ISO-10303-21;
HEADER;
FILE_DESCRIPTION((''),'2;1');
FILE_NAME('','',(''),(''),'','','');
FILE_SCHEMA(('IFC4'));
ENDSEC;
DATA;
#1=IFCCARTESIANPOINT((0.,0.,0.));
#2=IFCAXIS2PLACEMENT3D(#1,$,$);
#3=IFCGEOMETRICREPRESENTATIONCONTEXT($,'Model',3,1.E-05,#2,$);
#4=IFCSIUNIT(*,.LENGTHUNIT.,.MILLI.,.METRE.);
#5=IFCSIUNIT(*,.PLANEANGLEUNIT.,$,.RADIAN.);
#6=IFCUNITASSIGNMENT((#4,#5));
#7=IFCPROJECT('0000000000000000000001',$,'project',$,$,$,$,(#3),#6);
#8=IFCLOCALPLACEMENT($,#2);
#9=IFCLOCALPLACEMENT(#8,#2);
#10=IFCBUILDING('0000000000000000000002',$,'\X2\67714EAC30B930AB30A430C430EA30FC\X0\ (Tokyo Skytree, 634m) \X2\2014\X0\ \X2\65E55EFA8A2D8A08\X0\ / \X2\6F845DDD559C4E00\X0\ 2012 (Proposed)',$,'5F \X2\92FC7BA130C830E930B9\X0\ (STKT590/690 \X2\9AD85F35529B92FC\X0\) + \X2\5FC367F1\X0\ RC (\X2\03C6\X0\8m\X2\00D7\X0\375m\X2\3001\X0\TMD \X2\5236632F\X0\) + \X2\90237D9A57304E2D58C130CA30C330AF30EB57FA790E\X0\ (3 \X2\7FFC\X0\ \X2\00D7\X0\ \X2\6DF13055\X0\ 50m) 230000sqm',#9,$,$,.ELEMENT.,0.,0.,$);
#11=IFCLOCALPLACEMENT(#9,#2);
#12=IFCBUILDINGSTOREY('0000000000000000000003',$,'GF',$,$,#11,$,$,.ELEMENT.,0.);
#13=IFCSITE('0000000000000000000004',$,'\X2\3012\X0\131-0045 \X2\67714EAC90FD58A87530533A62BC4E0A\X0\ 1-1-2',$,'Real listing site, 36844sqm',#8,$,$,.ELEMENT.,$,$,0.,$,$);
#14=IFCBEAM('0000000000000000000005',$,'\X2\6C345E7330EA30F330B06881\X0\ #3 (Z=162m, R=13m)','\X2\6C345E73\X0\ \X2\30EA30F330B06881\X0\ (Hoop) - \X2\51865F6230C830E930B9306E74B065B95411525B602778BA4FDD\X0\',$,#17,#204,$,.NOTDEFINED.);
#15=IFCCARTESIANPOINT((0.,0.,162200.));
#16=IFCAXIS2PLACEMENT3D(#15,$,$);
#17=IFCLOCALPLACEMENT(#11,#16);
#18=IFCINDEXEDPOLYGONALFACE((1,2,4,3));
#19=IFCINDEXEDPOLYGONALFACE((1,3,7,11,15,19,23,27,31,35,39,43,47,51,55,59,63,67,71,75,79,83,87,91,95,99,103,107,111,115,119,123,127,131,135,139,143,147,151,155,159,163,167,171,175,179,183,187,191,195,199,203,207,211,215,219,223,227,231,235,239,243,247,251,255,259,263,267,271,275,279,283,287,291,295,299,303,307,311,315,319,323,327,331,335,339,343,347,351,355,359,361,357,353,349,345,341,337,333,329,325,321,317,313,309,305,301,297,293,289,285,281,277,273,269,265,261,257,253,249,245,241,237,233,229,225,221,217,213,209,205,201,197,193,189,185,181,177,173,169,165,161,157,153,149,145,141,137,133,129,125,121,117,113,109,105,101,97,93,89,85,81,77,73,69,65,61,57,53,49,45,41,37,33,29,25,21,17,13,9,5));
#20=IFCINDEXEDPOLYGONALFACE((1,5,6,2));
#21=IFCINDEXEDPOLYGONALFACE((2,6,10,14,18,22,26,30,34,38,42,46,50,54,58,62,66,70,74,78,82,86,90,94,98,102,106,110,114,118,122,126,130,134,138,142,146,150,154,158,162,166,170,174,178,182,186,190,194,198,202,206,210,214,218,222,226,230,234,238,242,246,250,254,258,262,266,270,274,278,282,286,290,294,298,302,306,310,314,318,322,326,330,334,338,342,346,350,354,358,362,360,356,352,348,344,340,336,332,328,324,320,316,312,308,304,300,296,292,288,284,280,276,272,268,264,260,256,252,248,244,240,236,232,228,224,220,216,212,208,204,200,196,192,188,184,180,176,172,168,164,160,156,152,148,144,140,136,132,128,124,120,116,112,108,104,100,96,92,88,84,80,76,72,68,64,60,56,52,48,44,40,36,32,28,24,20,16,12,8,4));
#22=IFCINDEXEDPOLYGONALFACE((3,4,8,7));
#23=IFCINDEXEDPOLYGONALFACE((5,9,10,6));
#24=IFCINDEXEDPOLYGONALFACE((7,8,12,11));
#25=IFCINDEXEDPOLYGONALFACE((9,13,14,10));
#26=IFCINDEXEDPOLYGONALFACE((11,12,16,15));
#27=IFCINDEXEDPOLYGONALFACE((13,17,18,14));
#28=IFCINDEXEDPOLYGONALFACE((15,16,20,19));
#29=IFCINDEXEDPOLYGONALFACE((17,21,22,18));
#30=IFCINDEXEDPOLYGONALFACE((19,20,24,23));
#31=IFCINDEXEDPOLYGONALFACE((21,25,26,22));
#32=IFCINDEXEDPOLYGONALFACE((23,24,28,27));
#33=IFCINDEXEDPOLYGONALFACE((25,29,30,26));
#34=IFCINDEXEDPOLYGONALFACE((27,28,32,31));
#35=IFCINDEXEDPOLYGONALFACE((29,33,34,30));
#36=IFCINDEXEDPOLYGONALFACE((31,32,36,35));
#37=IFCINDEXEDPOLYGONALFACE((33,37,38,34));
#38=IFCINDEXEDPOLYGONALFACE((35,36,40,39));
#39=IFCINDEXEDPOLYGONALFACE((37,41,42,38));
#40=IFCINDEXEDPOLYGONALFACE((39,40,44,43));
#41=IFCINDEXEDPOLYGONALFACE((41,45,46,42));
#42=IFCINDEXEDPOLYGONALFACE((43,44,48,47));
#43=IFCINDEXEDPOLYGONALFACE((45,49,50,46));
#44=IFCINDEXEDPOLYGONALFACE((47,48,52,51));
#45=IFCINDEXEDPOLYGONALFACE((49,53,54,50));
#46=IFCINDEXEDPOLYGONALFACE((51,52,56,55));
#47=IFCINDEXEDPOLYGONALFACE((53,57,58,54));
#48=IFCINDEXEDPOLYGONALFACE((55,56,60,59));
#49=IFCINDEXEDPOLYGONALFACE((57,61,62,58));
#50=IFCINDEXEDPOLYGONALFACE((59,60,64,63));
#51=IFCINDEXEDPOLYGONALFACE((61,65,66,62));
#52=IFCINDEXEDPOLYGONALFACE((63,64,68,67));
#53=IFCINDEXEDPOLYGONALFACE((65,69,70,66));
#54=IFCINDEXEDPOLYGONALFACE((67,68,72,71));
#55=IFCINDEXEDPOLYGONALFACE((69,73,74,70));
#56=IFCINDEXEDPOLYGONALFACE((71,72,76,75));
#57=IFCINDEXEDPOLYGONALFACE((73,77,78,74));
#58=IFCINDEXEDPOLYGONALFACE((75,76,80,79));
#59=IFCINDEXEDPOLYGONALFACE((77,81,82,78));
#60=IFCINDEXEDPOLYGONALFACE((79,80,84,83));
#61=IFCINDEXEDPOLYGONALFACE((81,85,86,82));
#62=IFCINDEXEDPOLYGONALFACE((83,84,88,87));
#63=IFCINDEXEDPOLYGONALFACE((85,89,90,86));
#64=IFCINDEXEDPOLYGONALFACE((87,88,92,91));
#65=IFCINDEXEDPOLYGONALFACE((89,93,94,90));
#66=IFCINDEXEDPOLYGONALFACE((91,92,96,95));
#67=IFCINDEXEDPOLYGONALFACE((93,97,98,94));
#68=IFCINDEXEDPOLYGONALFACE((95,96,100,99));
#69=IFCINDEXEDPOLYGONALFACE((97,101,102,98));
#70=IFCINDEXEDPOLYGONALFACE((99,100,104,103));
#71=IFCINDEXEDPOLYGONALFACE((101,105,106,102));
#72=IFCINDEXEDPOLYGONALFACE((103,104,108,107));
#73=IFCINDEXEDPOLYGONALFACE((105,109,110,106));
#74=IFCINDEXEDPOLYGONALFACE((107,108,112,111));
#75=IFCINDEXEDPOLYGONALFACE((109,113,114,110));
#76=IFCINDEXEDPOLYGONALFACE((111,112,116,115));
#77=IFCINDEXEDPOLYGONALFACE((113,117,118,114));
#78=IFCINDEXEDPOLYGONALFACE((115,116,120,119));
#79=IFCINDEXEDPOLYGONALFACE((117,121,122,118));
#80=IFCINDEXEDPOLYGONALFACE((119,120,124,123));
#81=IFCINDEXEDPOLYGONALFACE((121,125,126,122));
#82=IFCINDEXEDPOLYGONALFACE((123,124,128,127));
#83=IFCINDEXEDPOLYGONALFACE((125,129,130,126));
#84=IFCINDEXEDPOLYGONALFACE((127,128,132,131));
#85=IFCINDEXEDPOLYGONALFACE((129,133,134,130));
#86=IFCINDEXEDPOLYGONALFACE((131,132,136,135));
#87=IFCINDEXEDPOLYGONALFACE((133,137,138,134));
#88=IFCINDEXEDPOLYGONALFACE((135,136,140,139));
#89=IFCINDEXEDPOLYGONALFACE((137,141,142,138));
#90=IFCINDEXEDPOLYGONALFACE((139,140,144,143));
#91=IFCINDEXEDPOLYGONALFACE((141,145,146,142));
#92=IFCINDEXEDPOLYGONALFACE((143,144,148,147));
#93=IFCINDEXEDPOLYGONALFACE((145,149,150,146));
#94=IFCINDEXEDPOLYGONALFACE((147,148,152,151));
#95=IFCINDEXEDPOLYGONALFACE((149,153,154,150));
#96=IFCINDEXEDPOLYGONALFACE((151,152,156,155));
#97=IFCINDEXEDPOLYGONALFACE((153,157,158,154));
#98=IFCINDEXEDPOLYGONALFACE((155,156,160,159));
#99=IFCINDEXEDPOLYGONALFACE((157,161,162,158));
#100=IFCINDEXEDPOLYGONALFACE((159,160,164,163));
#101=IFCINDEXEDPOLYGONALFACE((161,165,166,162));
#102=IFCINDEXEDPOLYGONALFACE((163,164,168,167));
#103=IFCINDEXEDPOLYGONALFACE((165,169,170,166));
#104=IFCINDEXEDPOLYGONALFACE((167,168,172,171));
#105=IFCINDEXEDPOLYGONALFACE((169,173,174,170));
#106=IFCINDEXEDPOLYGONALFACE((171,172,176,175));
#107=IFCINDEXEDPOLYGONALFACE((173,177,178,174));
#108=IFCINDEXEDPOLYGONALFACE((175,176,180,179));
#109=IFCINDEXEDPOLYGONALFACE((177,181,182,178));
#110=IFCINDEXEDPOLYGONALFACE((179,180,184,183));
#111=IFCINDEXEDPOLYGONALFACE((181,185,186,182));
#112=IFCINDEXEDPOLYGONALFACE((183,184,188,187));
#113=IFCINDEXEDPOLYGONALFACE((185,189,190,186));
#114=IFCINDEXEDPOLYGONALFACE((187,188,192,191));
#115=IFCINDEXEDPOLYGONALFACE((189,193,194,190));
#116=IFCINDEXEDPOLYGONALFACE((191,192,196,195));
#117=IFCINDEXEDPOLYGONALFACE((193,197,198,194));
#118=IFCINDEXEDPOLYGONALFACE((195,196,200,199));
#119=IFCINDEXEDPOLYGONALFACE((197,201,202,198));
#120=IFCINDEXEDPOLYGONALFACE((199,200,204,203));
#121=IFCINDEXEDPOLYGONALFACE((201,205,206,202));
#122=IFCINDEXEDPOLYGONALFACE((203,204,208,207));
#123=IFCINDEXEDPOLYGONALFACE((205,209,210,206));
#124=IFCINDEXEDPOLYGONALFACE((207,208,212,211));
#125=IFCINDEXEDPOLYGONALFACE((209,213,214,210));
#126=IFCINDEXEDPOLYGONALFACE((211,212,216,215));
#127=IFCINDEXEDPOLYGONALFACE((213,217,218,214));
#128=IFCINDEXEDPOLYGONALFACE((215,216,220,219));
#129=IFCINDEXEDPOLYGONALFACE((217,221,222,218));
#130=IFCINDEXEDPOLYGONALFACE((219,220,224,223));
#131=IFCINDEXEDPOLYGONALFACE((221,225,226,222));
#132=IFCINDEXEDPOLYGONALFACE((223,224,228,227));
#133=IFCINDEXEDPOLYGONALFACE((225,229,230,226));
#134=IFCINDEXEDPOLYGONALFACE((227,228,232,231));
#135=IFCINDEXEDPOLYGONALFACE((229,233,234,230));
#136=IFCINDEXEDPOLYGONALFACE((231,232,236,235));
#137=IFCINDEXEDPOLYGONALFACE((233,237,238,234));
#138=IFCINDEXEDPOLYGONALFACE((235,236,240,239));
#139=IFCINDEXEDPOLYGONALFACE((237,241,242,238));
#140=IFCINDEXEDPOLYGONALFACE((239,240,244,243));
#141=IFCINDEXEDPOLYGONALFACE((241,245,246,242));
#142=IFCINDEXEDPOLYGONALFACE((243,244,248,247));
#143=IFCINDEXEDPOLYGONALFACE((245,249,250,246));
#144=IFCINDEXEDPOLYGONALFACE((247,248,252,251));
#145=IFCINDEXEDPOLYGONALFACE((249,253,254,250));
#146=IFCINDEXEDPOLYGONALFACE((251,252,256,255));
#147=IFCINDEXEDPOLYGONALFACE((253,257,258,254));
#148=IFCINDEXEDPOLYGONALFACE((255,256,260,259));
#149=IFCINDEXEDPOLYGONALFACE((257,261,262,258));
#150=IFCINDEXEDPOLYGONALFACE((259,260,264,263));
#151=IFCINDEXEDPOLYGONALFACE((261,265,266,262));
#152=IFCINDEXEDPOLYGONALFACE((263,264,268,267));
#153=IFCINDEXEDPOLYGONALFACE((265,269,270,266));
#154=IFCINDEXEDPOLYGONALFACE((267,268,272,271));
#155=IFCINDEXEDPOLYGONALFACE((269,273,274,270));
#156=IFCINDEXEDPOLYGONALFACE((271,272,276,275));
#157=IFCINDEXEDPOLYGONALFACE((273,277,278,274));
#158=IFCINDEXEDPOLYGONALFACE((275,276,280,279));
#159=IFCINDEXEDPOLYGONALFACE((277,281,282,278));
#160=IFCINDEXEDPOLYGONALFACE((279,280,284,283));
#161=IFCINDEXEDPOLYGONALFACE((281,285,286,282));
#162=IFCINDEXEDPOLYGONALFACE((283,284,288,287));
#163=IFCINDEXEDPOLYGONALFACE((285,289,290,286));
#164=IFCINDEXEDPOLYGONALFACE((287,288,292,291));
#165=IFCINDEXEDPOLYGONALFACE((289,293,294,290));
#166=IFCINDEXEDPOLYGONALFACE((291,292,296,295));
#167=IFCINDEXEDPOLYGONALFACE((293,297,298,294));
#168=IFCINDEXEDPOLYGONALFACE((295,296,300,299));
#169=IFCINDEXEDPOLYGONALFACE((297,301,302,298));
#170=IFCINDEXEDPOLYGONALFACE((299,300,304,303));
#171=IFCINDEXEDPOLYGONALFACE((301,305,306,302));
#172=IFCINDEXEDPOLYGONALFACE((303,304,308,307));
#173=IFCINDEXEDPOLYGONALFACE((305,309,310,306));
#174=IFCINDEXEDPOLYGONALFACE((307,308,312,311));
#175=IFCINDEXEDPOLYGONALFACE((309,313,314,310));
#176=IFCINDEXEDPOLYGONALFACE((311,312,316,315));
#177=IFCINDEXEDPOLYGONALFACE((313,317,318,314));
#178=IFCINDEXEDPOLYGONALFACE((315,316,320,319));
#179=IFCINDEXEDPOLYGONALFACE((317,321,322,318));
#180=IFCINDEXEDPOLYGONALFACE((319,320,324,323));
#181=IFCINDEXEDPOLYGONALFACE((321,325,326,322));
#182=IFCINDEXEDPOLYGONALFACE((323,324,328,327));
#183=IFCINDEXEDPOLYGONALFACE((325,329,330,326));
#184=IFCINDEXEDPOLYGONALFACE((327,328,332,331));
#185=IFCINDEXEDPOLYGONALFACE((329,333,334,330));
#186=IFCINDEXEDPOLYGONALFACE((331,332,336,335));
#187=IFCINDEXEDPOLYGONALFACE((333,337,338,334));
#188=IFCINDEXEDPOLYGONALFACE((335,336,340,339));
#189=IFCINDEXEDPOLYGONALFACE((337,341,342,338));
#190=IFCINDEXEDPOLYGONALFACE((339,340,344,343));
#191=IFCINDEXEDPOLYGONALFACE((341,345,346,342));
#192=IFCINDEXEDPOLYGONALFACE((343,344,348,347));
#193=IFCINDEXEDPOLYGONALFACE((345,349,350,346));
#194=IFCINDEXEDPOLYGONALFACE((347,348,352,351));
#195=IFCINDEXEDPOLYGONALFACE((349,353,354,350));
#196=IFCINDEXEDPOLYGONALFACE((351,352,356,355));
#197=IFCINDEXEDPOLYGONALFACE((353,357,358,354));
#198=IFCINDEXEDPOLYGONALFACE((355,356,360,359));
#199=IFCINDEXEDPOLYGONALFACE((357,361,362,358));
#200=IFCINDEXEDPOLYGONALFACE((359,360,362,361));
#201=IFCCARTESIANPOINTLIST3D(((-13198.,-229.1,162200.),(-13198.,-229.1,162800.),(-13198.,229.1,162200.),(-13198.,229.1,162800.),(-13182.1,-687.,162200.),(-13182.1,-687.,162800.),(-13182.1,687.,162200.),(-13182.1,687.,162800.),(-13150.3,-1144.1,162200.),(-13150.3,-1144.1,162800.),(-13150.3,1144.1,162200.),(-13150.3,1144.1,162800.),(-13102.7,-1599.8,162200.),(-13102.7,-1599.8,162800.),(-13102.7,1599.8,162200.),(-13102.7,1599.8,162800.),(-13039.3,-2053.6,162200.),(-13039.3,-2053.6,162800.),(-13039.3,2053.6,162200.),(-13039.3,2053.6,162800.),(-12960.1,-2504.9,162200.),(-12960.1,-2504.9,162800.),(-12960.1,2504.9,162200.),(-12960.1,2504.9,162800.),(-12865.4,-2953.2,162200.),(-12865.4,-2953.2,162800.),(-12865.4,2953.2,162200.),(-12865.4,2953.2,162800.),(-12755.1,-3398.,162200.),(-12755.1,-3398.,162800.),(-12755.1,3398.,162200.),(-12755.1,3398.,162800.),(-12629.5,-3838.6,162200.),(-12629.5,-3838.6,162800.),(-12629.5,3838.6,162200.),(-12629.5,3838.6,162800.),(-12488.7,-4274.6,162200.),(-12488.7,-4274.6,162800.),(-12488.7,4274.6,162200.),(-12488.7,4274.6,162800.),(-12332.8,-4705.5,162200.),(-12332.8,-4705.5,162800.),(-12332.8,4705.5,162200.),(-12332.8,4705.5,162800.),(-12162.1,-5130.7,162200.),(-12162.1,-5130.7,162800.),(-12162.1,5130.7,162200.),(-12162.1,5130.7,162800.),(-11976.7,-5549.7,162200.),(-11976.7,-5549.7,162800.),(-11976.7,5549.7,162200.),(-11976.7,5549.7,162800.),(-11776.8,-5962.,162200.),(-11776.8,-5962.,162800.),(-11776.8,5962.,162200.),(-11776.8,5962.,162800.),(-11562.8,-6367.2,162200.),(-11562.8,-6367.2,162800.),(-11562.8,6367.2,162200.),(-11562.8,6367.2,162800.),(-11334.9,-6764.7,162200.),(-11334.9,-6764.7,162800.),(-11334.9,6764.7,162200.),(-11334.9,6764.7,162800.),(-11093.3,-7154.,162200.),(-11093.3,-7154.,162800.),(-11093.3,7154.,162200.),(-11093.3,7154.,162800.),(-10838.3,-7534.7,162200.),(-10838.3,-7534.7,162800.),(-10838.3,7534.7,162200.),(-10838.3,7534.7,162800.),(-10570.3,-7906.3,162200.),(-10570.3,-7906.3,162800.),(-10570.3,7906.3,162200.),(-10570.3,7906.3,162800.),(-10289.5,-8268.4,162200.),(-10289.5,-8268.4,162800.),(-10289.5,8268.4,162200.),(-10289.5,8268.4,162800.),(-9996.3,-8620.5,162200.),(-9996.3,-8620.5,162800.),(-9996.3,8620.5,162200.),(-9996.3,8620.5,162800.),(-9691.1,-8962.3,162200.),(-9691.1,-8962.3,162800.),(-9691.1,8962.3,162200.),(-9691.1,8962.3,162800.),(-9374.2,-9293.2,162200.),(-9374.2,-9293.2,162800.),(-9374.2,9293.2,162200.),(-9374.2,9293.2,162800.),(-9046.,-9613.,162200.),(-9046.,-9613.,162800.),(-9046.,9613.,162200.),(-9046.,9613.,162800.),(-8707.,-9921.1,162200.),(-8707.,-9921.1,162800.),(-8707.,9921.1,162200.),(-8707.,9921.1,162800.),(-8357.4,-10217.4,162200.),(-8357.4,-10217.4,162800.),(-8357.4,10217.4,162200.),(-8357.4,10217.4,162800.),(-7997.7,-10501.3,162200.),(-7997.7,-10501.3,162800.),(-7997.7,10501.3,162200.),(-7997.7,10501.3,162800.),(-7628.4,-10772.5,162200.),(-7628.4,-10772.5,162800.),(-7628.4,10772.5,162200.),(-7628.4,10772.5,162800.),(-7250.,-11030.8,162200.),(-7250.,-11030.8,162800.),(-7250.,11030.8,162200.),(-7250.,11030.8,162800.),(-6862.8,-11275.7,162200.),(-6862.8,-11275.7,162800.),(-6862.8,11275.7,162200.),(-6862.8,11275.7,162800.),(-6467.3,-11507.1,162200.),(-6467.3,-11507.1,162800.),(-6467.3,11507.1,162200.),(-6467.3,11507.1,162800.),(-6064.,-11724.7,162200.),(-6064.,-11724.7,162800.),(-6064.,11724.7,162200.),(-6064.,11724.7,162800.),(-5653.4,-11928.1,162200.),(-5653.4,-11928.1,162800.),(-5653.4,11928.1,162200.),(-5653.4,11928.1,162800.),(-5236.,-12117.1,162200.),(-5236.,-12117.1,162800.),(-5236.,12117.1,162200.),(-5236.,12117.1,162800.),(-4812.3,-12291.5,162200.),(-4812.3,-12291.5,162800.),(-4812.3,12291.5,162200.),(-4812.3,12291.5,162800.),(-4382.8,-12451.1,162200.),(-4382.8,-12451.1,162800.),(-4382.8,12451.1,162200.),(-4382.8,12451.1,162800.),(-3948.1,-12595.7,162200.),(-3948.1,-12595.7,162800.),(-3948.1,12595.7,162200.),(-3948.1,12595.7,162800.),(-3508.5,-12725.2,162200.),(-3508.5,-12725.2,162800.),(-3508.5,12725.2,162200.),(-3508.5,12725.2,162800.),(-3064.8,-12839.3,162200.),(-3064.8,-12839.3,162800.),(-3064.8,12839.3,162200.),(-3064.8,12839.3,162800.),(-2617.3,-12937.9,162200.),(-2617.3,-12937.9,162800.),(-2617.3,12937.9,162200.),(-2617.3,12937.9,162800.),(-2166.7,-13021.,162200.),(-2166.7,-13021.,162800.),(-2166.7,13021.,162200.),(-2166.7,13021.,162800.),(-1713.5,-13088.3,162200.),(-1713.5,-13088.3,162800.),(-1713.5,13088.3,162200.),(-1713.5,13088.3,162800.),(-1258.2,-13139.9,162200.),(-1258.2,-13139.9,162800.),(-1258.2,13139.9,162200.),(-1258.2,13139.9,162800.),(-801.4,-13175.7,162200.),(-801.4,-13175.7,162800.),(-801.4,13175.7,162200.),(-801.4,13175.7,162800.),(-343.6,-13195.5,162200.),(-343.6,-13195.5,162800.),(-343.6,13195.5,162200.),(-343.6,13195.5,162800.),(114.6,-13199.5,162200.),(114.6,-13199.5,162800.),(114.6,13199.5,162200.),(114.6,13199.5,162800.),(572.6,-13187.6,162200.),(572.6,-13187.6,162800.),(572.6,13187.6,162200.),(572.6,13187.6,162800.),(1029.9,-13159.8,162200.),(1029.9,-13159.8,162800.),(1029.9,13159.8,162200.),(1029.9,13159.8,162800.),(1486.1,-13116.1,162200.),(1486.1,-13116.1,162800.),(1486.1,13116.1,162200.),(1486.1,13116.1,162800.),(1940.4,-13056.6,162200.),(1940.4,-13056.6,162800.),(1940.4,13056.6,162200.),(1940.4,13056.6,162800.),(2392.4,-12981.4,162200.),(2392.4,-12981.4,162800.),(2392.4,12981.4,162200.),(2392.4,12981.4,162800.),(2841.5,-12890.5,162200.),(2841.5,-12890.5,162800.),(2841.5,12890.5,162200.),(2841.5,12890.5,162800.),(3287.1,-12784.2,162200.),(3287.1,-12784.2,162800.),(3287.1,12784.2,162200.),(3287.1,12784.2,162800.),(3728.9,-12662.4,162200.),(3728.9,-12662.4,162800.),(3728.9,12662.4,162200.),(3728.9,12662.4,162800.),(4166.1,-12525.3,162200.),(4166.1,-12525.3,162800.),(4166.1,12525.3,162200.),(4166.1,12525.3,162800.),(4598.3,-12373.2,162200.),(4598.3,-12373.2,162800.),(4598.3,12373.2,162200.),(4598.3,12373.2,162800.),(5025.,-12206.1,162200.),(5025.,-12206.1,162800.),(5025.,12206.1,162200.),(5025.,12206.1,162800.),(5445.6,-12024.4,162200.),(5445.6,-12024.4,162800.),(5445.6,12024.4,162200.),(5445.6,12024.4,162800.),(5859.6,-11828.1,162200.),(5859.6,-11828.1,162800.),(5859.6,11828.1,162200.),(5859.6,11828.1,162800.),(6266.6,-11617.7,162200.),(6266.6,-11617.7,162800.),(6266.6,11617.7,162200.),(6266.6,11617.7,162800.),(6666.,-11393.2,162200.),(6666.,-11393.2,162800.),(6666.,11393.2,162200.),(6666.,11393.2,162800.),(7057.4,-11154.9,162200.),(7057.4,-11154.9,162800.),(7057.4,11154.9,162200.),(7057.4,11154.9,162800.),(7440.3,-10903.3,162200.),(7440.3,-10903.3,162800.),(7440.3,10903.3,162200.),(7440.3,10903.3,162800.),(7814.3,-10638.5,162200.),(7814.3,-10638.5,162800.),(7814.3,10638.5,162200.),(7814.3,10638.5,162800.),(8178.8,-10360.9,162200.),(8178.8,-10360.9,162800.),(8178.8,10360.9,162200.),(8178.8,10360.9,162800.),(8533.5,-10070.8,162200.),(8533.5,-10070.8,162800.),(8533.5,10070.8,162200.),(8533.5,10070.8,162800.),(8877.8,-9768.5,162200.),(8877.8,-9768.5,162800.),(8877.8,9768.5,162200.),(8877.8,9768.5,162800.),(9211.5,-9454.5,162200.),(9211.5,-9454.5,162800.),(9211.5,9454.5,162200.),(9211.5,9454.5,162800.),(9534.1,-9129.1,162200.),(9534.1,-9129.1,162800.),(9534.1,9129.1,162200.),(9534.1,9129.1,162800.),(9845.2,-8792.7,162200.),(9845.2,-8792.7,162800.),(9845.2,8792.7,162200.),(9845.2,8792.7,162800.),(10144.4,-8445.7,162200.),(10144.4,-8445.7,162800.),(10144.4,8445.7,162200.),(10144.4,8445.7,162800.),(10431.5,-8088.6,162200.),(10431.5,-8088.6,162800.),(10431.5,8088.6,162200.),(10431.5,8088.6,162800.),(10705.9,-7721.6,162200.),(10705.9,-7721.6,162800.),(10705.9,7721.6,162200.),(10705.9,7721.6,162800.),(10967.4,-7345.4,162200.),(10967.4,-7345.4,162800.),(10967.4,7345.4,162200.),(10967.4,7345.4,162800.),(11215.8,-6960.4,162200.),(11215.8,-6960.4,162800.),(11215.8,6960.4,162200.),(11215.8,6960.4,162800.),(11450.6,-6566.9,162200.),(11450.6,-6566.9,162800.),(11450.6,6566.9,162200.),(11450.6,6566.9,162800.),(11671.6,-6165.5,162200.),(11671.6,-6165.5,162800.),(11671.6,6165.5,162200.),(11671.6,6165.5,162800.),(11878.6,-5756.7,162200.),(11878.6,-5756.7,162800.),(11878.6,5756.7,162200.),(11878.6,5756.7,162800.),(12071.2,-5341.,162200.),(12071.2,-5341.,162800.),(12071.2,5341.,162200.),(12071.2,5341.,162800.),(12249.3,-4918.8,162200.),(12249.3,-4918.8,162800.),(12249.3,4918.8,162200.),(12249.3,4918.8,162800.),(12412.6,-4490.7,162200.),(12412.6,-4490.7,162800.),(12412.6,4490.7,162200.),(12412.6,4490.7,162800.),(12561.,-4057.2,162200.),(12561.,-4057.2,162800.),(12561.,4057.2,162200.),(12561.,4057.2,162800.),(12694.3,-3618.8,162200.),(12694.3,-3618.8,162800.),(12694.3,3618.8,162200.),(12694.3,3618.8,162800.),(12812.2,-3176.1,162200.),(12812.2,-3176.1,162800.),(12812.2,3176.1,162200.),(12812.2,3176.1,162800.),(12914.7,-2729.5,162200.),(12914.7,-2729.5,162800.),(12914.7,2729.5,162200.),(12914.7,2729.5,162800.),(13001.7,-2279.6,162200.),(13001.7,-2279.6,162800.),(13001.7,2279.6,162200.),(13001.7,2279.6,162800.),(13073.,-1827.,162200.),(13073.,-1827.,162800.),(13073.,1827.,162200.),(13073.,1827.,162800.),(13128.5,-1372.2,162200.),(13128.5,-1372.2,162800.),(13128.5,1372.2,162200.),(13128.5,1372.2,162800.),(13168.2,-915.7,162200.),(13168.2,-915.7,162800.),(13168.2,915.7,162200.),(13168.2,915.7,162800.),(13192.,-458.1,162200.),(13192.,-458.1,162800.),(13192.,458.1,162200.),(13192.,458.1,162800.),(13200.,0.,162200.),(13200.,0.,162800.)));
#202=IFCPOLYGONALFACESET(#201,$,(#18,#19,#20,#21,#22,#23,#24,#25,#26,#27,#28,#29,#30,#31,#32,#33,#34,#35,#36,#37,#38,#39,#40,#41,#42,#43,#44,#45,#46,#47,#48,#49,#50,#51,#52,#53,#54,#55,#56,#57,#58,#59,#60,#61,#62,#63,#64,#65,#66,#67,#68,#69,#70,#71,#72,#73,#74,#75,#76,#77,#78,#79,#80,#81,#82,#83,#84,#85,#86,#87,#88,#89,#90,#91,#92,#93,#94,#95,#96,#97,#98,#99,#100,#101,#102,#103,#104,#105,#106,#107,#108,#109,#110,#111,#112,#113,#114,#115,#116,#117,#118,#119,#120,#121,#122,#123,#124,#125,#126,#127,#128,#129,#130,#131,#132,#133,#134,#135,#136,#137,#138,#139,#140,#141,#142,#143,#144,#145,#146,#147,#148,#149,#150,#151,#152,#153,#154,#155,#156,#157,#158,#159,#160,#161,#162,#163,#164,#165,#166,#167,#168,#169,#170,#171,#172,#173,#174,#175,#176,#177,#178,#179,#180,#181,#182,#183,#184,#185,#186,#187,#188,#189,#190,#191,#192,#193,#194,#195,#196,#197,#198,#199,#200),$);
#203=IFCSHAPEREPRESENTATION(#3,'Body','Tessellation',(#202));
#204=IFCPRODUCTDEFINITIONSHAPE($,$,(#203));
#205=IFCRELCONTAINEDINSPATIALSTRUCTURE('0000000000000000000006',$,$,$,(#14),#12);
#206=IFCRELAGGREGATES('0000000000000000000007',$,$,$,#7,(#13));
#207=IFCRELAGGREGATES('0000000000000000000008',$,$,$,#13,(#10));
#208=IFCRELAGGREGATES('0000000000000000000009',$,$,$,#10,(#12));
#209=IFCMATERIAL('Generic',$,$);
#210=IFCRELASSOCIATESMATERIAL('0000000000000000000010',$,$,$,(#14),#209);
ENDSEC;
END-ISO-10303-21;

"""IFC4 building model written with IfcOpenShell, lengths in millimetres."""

from ifc_helpers import new_model, si_unit, frame, origin, origin_2d, place, context, project, spatial, circle, extrude, material, element, save


model = new_model("IFC4")

# Units and contexts
model_context = context("Model", 3, precision=1e-05, world=origin())
ifc_project = project(units=[si_unit("LENGTHUNIT", "METRE", prefix="MILLI"), si_unit("PLANEANGLEUNIT", "RADIAN")], contexts=[model_context])

# Site, building, storey
site_placement = place(None, origin())
site = spatial("IfcSite", under=ifc_project, at=site_placement, Name="〒131-0045 東京都墨田区押上 1-1-2", ObjectType="Real listing site, 36844sqm", CompositionType="ELEMENT", RefElevation=0.0)
building_placement = place(site_placement, origin())
building = spatial("IfcBuilding", under=site, at=building_placement, Name="東京スカイツリー (Tokyo Skytree, 634m) — 日建設計 / 澄川喜一 2012 (Proposed)", ObjectType="5F 鋼管トラス (STKT590/690 高張力鋼) + 心柱 RC (φ8m×375m、TMD 制振) + 連続地中壁ナックル基礎 (3 翼 × 深さ 50m) 230000sqm", CompositionType="ELEMENT", ElevationOfRefHeight=0.0, ElevationOfTerrain=0.0)
storey_placement = place(building_placement, origin())
storey = spatial("IfcBuildingStorey", under=building, at=storey_placement, Name="GF", CompositionType="ELEMENT", Elevation=0.0)

# Shared definitions
ifc_material_1 = material(Name="Generic")

# Beam
beam_1_placement = place(storey_placement, frame((0.0, 0.0, 162200.0)))
element("IfcBeam", 1, at=beam_1_placement, inside=storey, material=ifc_material_1, Name="水平リング梁 #3 (Z=162m, R=13m)", Description="水平 リング梁 (Hoop) - 円形トラスの環方向剛性確保", PredefinedType="NOTDEFINED", context=model_context, shape_type="SweptSolid", body=[
    extrude(circle(Radius=13200.0, at=origin_2d()), frame((0.0, 0.0, 162200.0)), (0.0, 0.0, 1.0), 600.0),
])

save(model, "model.ifc")
